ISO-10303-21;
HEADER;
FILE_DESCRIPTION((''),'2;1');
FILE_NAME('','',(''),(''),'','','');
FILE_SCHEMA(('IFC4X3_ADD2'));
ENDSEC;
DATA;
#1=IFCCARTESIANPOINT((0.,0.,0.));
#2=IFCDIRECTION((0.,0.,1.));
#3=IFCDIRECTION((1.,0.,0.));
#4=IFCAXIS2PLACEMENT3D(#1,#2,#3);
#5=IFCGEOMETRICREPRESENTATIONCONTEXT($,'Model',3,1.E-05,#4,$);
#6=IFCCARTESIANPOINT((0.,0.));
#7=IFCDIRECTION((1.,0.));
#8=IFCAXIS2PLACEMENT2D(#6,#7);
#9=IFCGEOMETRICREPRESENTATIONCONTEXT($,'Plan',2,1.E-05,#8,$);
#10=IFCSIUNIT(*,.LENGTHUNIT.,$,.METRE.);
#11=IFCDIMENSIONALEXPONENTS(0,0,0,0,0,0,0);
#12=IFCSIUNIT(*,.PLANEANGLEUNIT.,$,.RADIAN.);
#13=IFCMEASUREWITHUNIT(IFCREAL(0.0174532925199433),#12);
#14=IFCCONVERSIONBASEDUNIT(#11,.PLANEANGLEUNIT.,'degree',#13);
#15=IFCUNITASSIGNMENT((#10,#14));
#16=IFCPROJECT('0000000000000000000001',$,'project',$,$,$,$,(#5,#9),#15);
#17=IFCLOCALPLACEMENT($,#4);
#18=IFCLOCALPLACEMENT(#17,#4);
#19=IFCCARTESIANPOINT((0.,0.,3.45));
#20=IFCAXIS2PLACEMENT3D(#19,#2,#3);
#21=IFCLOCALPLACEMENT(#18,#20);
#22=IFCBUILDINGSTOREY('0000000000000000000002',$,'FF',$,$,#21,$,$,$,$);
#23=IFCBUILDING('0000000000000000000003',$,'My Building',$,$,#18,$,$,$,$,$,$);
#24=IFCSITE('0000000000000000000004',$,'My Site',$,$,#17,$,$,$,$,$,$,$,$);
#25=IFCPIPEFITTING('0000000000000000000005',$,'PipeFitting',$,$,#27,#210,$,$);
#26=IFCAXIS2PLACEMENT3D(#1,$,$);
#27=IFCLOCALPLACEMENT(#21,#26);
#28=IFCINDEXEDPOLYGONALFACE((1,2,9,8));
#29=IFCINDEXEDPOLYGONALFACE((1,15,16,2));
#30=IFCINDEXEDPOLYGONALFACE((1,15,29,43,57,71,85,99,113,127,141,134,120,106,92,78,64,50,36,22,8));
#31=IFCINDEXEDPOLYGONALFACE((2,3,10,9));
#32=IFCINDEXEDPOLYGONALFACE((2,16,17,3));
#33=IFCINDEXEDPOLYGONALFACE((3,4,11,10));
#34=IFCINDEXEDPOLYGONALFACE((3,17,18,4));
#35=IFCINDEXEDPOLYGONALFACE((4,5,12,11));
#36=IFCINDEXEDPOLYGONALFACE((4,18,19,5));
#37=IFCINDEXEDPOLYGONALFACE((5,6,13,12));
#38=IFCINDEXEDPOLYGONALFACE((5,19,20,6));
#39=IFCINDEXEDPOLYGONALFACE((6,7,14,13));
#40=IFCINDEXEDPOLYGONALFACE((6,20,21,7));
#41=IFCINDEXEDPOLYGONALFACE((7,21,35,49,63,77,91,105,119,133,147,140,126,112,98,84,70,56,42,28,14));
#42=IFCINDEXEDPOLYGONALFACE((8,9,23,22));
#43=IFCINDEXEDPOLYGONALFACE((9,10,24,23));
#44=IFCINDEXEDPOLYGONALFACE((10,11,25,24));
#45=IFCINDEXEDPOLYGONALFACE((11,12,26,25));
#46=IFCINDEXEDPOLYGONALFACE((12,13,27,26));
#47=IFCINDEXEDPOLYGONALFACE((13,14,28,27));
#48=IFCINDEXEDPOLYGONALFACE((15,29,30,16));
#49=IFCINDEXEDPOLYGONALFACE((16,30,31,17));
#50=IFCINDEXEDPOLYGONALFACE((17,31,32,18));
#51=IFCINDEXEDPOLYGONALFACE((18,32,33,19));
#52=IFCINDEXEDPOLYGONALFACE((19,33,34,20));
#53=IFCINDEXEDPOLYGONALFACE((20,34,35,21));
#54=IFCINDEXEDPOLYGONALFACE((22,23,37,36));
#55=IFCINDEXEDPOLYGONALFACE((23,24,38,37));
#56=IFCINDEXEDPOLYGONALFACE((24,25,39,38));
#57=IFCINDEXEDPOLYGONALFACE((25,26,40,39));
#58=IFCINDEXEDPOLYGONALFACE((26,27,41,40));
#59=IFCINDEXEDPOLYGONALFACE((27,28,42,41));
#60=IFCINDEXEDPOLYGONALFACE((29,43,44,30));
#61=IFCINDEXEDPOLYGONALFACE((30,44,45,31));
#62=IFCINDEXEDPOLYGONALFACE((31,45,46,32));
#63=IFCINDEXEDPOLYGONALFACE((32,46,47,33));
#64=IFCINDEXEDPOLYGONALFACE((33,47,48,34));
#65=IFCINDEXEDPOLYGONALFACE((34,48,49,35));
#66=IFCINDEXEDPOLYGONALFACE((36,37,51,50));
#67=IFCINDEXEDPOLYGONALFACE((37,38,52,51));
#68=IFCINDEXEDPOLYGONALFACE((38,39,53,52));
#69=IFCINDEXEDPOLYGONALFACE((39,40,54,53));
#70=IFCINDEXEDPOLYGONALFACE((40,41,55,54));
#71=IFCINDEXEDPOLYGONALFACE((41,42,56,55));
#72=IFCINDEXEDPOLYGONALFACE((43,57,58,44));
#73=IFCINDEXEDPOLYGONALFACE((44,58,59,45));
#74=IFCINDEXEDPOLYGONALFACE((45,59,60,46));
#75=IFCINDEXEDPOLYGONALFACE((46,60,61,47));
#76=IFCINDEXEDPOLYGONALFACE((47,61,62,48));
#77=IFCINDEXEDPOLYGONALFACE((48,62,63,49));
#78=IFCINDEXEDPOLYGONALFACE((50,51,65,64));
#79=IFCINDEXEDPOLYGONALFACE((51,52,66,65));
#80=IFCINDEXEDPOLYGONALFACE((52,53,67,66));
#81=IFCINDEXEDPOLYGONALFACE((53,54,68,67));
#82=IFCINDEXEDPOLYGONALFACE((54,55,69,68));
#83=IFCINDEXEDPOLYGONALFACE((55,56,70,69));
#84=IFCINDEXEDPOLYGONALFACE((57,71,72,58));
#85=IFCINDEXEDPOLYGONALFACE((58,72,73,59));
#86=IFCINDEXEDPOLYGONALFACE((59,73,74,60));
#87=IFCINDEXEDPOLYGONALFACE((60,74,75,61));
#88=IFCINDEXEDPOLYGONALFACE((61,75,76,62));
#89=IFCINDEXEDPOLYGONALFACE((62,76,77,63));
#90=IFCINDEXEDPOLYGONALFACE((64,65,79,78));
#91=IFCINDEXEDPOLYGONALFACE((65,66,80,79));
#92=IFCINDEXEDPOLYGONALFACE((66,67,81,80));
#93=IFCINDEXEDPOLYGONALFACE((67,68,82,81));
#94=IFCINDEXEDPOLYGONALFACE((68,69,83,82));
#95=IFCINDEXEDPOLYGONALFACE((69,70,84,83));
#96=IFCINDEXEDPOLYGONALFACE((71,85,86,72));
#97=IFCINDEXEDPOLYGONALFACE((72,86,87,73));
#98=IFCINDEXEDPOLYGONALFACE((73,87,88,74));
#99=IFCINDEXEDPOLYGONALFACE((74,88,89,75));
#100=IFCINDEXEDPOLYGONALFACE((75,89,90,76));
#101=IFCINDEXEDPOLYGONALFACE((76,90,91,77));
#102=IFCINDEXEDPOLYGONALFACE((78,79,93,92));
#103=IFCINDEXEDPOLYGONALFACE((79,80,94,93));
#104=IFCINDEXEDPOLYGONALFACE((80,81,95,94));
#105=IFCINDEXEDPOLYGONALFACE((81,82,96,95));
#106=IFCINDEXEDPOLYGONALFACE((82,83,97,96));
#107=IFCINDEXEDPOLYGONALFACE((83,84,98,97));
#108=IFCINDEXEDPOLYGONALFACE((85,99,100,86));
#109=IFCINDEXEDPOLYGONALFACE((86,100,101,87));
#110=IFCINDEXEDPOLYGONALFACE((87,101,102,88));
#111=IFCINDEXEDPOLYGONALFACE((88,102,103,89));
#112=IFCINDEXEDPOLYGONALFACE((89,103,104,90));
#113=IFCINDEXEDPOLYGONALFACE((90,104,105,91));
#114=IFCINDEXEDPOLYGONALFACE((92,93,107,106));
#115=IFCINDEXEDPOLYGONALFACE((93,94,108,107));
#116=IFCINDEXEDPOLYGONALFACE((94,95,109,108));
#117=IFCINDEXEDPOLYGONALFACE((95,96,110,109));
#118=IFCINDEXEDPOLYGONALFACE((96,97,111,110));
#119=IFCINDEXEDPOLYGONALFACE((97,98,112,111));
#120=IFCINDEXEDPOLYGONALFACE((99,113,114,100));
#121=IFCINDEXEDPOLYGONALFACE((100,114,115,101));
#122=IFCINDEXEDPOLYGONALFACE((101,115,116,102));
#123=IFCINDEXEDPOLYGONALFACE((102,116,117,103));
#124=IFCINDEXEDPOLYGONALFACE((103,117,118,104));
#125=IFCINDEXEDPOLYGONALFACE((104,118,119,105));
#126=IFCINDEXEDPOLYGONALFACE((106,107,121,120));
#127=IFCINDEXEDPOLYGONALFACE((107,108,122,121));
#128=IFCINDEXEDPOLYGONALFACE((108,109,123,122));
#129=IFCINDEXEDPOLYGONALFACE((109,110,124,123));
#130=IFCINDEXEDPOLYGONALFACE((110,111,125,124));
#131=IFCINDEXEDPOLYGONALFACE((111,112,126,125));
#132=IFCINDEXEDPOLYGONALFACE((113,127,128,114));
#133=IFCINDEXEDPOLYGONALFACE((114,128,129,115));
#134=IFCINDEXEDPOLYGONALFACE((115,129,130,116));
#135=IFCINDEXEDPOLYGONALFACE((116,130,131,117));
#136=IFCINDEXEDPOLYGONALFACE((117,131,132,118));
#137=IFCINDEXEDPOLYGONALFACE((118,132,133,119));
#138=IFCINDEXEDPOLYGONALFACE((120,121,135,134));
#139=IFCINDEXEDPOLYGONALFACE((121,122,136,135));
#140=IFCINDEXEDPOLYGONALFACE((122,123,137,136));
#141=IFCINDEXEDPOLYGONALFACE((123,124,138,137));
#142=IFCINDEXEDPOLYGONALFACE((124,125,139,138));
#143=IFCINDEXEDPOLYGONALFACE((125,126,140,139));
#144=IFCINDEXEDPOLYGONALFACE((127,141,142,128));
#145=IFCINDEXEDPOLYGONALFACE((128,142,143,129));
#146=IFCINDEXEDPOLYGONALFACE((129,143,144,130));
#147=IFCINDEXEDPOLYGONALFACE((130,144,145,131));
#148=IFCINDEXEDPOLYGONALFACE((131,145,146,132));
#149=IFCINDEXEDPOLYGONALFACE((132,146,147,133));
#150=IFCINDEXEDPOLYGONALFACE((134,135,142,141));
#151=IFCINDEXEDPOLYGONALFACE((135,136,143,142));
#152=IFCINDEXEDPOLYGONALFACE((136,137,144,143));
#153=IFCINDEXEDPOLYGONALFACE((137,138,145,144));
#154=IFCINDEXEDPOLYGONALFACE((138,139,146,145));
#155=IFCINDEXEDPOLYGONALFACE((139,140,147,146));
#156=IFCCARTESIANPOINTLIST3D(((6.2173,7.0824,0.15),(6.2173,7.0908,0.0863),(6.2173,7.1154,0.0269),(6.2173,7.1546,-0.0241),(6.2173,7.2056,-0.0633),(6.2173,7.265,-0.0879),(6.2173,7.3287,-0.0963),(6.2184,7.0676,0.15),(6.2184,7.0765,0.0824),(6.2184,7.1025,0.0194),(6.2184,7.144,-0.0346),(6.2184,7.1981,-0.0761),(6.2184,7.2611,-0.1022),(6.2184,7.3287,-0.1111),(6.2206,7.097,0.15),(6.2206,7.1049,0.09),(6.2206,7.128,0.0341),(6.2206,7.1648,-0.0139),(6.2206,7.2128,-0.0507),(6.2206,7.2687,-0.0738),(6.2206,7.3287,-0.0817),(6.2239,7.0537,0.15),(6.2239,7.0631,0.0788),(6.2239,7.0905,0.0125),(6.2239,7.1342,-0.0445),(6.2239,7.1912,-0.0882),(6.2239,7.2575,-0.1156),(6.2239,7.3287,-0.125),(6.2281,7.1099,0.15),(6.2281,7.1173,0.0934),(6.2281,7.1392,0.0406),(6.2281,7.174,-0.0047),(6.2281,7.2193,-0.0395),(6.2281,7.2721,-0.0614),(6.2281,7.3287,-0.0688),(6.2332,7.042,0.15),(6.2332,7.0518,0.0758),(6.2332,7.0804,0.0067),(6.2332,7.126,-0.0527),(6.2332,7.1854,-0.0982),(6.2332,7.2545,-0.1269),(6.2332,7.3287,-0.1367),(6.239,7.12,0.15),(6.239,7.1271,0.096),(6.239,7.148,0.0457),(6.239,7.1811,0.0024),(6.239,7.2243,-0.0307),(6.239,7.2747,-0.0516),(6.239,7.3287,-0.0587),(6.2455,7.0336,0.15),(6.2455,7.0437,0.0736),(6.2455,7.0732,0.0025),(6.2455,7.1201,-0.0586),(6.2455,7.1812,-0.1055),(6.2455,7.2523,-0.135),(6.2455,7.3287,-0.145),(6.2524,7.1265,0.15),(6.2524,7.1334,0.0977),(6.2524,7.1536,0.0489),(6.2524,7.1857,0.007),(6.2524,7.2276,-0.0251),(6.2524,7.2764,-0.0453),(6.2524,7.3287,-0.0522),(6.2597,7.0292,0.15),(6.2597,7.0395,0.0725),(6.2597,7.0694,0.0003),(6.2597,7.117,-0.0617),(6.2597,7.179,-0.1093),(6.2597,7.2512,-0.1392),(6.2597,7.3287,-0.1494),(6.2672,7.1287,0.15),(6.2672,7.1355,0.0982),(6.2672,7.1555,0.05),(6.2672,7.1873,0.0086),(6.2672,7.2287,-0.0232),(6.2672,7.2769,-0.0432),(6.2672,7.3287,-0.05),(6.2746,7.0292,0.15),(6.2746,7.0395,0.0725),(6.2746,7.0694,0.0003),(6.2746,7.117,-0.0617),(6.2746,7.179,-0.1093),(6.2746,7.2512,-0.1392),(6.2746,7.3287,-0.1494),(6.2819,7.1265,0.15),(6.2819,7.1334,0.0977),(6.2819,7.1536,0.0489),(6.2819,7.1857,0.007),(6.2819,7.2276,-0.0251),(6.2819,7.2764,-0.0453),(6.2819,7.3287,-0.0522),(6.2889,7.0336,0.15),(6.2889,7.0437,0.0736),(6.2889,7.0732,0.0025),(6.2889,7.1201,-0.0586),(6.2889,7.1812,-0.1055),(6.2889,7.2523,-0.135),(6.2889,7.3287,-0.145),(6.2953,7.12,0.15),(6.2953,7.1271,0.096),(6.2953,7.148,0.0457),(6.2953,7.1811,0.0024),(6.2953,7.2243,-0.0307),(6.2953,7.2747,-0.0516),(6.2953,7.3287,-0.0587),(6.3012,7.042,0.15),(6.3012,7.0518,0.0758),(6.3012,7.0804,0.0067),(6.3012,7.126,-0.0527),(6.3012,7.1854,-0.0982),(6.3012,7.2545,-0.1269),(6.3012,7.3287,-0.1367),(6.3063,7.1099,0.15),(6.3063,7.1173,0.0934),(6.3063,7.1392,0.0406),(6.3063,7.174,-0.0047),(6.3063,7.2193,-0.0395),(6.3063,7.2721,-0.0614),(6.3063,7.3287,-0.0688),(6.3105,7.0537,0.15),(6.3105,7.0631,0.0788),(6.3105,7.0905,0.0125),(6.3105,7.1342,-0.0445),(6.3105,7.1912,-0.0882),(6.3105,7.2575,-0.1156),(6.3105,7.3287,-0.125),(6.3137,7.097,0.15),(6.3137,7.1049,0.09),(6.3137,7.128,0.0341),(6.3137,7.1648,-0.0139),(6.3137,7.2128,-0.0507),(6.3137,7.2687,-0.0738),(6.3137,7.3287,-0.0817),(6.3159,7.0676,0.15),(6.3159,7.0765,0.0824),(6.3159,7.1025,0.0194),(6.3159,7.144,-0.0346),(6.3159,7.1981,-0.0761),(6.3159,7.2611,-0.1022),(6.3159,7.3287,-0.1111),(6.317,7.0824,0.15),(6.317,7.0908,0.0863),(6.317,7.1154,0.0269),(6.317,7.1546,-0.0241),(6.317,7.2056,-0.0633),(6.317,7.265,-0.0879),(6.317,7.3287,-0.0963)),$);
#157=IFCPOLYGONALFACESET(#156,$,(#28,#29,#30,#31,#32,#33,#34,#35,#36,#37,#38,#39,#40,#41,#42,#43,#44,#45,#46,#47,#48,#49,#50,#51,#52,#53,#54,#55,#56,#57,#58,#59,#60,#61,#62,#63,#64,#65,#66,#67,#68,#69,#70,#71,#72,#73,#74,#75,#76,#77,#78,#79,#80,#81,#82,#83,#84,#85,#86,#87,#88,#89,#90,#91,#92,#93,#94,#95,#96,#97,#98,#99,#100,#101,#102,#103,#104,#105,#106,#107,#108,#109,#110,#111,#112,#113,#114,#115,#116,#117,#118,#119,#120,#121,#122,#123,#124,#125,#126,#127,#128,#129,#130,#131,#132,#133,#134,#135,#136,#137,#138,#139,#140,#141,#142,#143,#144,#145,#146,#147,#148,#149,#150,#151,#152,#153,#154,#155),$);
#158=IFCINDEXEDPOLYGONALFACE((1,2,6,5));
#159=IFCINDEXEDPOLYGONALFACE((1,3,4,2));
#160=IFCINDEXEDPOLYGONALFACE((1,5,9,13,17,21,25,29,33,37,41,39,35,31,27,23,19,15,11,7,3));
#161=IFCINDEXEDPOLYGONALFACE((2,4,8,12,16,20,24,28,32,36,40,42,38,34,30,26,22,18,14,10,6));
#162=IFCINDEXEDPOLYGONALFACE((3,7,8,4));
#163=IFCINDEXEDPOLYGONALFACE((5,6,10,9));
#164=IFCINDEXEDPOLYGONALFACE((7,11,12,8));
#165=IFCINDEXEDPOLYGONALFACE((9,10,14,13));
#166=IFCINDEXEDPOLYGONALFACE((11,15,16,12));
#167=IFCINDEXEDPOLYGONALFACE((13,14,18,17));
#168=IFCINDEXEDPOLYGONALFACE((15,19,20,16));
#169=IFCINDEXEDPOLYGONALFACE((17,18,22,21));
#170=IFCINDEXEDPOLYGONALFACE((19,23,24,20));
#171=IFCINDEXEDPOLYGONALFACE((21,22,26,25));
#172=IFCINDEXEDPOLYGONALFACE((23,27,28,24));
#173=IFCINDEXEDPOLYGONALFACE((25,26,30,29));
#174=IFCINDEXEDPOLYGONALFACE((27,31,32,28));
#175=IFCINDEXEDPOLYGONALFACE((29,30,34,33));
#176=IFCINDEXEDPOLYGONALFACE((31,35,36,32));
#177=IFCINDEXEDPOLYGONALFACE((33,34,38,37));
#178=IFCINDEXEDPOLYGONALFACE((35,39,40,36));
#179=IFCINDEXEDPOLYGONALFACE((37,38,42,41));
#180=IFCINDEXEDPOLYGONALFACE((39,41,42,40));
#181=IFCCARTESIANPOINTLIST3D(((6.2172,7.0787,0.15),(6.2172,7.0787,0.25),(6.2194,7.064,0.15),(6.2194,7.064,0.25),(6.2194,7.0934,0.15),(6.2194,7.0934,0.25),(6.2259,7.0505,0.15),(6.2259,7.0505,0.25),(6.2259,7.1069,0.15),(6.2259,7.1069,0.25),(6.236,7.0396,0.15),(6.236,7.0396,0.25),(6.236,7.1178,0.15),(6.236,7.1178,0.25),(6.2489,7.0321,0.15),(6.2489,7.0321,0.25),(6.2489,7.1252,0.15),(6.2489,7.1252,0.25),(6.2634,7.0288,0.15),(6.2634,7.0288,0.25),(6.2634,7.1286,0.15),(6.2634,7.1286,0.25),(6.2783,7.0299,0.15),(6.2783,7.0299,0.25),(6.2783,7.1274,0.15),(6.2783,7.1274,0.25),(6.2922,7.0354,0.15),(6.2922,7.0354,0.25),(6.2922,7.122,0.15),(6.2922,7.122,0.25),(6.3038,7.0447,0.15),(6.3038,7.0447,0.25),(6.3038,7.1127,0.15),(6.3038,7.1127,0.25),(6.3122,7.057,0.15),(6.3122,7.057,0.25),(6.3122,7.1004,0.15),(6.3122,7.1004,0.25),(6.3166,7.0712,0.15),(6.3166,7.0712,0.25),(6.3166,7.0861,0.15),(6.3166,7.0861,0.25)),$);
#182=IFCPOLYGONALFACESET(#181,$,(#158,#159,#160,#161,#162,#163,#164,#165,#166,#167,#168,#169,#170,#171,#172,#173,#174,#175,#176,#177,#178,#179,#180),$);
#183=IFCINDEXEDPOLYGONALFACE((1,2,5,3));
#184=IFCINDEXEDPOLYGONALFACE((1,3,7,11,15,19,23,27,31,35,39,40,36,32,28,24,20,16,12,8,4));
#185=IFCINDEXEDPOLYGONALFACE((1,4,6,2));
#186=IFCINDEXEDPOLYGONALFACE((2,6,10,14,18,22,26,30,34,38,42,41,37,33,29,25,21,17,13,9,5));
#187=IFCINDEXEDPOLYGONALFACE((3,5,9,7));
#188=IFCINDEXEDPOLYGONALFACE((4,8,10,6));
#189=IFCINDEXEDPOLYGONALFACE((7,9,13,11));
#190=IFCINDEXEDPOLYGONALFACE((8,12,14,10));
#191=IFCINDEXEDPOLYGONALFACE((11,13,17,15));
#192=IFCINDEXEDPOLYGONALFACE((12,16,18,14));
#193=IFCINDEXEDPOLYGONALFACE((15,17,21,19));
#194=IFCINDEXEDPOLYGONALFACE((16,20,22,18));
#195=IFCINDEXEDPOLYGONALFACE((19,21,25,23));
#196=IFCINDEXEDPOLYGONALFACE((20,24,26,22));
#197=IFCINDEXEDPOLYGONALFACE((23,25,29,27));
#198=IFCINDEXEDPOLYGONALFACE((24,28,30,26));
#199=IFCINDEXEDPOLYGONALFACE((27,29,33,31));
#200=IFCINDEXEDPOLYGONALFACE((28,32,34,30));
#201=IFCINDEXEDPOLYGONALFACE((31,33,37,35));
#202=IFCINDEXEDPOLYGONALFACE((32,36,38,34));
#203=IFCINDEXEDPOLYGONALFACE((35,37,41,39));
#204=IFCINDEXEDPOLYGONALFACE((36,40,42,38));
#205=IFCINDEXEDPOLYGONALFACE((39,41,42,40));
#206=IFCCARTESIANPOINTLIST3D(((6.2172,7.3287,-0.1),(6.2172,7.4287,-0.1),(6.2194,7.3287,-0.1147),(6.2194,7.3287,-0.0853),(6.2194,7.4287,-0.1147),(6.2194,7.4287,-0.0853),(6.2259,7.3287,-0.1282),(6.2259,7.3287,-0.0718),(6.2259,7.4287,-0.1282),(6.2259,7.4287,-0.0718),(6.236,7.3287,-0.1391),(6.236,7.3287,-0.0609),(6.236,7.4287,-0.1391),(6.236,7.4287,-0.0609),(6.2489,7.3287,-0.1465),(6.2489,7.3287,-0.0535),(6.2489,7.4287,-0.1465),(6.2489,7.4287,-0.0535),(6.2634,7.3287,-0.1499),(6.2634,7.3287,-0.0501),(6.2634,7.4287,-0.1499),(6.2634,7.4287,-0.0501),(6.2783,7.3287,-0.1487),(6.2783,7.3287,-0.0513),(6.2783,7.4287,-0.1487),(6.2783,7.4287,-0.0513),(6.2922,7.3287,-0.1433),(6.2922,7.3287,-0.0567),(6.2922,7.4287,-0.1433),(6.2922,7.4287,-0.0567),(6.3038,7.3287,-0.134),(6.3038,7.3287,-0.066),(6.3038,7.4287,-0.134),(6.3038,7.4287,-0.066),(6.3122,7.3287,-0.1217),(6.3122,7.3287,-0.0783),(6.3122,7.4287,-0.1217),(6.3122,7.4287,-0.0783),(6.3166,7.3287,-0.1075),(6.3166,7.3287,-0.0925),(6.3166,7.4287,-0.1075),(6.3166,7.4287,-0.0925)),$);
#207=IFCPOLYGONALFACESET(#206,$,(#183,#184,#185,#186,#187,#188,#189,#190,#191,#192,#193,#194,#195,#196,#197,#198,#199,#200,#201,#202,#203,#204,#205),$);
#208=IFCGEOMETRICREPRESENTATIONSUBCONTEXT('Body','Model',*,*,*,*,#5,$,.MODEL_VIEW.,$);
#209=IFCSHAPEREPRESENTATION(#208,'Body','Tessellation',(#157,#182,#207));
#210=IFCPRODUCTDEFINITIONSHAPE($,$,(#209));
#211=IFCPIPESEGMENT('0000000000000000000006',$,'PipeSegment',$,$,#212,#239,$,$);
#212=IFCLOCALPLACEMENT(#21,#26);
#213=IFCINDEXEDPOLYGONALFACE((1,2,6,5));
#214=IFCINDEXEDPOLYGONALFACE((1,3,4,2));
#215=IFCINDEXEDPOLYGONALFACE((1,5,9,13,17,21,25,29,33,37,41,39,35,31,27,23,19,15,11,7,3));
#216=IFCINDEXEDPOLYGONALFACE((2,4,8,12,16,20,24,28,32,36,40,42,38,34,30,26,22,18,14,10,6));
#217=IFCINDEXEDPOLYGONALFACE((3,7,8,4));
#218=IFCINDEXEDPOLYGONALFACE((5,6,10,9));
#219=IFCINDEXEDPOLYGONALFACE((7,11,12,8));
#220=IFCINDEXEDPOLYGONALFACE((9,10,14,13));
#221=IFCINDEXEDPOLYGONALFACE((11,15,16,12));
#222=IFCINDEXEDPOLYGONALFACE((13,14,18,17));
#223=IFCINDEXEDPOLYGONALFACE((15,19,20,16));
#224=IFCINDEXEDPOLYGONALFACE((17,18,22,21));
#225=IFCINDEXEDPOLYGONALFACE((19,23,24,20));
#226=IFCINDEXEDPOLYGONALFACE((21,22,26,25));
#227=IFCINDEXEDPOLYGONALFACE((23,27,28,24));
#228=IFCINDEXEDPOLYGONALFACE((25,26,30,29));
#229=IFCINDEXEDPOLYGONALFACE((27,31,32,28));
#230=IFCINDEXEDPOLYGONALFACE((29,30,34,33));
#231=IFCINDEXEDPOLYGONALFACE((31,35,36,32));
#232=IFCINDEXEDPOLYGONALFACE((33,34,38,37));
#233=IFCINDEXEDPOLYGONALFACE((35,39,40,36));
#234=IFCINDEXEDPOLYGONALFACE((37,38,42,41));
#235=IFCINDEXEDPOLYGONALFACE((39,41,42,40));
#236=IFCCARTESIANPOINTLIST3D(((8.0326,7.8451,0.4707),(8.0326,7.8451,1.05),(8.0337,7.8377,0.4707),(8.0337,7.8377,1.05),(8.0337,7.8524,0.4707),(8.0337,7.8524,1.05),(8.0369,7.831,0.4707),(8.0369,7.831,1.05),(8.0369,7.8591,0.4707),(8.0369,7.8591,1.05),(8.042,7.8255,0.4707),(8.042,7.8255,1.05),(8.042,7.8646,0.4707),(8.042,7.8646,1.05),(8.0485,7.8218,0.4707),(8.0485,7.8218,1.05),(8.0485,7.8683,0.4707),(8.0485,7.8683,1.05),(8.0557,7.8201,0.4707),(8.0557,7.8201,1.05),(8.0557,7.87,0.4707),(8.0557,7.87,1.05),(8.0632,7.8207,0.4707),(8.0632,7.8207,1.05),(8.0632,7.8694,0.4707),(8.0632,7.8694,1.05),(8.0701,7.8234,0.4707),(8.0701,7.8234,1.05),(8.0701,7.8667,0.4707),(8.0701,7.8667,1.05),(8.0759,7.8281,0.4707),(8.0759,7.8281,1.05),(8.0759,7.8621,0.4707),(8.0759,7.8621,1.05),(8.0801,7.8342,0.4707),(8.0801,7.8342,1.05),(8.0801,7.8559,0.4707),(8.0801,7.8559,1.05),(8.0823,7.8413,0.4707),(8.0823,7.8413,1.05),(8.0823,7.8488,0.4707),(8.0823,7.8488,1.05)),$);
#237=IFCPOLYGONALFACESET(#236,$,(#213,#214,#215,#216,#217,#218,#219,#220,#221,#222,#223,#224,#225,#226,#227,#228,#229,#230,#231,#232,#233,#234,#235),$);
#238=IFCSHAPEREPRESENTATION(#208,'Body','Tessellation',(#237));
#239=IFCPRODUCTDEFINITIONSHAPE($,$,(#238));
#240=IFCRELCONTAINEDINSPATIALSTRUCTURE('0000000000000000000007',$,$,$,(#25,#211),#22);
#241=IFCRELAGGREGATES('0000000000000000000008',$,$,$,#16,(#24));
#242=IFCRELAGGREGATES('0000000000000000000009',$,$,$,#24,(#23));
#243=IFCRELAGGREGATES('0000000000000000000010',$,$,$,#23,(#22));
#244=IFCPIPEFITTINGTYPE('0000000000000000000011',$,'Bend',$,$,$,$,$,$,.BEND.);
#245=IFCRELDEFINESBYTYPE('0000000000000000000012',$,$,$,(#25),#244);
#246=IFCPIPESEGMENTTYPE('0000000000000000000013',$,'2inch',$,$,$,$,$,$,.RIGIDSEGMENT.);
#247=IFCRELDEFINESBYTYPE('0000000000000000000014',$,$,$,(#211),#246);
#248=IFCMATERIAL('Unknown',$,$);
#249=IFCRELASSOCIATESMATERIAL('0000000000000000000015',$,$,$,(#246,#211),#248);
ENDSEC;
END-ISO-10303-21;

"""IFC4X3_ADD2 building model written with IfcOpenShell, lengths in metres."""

from ifc_helpers import new_model, entity, si_unit, converted_unit, frame, origin_with_axes, origin_2d_with_axis, place, context, subcontext, project, spatial, circle, extrude, source, transform, mapped, material, material_profile, profile_set, profile_usage, type_object, type_shapes, element, save


model = new_model("IFC4X3_ADD2")

# Units and contexts
model_context = context("Model", 3, precision=1e-05, world=origin_with_axes())
plan_context = context("Plan", 2, precision=1e-05, world=origin_2d_with_axis())
body_context_1 = subcontext(model_context, "Body", "Model", "MODEL_VIEW")
ifc_project = project(units=[si_unit("LENGTHUNIT", "METRE"), converted_unit("PLANEANGLEUNIT", "degree", entity("IfcReal", 0.0174532925199433), si_unit("PLANEANGLEUNIT", "RADIAN"), dimensions=[0, 0, 0, 0, 0, 0, 0])], contexts=[model_context, plan_context])

# Site, building, storey
site_placement = place(None, origin_with_axes())
site = spatial("IfcSite", under=ifc_project, at=site_placement, Name="My Site")
building_placement = place(site_placement, origin_with_axes())
building = spatial("IfcBuilding", under=site, at=building_placement, Name="My Building")
storey_placement = place(building_placement, frame((0.0, 0.0, 3.45), z_axis=(0.0, 0.0, 1.0), x_axis=(1.0, 0.0, 0.0)))
storey = spatial("IfcBuildingStorey", under=building, at=storey_placement, Name="FF")

# Shared definitions
ifc_material = material(Name="Unknown")

# Pipe fitting
pipe_fitting_type = type_object("IfcPipeFittingType", Name="Bend", PredefinedType="BEND")
shared_shape_1 = source(origin_with_axes(), body_context_1, "Body", "SolidModel", [
    entity("IfcSweptDiskSolid", entity("IfcIndexedPolyCurve", entity("IfcCartesianPointList3D", [[0.0, 0.0, -0.1], [0.0, -0.0732, -0.2768], [0.0, -0.25, -0.35]]), [entity("IfcArcIndex", [1, 2, 3])]), 0.05),
    extrude(circle(Radius=0.05), origin_with_axes(), (0.0, 0.0, -1.0), 0.1),
    extrude(circle(Radius=0.05), frame((0.0, -0.25, -0.35), z_axis=(0.0, -1.0, 0.0), x_axis=(1.0, 0.0, 0.0)), (0.0, 0.0, 1.0), 0.1),
])
type_shapes(pipe_fitting_type, [shared_shape_1])
pipe_fitting_placement = place(storey_placement, frame((6.2672, 7.0787, 0.25), z_axis=(0.0, 0.0, 1.0), x_axis=(-1.0, 0.0, 0.0)))
element("IfcPipeFitting", 1, at=pipe_fitting_placement, inside=storey, type_object=pipe_fitting_type, Name="PipeFitting", context=body_context_1, shape_type="MappedRepresentation", body=[
    mapped(shared_shape_1, transform((0.0, 0.0, 0.0), x_axis=(1.0, 0.0, 0.0), y_axis=(0.0, 1.0, 0.0), z_axis=(0.0, 0.0, 1.0), scale=1.0)),
])

# Pipe segment
ifc_material_profile_1 = material_profile(ifc_material, circle(Radius=0.025))
ifc_profile_set_1 = profile_set([ifc_material_profile_1])
ifc_profile_usage_1 = profile_usage(ifc_profile_set_1)
pipe_segment_type_1 = type_object("IfcPipeSegmentType", Name="2inch", PredefinedType="RIGIDSEGMENT", material=ifc_profile_set_1)
pipe_segment_1_placement = place(storey_placement, frame((8.0576, 7.8451, 0.4707), z_axis=(0.0, 0.0, 1.0), x_axis=(-1.0, 0.0, 0.0)))
element("IfcPipeSegment", 2, at=pipe_segment_1_placement, inside=storey, type_object=pipe_segment_type_1, material=ifc_profile_usage_1, Name="PipeSegment", context=body_context_1, shape_type="SweptSolid", body=[
    extrude(circle(Radius=0.025), origin_with_axes(), (0.0, 0.0, 1.0), 0.5793),
])

save(model, "model.ifc")
